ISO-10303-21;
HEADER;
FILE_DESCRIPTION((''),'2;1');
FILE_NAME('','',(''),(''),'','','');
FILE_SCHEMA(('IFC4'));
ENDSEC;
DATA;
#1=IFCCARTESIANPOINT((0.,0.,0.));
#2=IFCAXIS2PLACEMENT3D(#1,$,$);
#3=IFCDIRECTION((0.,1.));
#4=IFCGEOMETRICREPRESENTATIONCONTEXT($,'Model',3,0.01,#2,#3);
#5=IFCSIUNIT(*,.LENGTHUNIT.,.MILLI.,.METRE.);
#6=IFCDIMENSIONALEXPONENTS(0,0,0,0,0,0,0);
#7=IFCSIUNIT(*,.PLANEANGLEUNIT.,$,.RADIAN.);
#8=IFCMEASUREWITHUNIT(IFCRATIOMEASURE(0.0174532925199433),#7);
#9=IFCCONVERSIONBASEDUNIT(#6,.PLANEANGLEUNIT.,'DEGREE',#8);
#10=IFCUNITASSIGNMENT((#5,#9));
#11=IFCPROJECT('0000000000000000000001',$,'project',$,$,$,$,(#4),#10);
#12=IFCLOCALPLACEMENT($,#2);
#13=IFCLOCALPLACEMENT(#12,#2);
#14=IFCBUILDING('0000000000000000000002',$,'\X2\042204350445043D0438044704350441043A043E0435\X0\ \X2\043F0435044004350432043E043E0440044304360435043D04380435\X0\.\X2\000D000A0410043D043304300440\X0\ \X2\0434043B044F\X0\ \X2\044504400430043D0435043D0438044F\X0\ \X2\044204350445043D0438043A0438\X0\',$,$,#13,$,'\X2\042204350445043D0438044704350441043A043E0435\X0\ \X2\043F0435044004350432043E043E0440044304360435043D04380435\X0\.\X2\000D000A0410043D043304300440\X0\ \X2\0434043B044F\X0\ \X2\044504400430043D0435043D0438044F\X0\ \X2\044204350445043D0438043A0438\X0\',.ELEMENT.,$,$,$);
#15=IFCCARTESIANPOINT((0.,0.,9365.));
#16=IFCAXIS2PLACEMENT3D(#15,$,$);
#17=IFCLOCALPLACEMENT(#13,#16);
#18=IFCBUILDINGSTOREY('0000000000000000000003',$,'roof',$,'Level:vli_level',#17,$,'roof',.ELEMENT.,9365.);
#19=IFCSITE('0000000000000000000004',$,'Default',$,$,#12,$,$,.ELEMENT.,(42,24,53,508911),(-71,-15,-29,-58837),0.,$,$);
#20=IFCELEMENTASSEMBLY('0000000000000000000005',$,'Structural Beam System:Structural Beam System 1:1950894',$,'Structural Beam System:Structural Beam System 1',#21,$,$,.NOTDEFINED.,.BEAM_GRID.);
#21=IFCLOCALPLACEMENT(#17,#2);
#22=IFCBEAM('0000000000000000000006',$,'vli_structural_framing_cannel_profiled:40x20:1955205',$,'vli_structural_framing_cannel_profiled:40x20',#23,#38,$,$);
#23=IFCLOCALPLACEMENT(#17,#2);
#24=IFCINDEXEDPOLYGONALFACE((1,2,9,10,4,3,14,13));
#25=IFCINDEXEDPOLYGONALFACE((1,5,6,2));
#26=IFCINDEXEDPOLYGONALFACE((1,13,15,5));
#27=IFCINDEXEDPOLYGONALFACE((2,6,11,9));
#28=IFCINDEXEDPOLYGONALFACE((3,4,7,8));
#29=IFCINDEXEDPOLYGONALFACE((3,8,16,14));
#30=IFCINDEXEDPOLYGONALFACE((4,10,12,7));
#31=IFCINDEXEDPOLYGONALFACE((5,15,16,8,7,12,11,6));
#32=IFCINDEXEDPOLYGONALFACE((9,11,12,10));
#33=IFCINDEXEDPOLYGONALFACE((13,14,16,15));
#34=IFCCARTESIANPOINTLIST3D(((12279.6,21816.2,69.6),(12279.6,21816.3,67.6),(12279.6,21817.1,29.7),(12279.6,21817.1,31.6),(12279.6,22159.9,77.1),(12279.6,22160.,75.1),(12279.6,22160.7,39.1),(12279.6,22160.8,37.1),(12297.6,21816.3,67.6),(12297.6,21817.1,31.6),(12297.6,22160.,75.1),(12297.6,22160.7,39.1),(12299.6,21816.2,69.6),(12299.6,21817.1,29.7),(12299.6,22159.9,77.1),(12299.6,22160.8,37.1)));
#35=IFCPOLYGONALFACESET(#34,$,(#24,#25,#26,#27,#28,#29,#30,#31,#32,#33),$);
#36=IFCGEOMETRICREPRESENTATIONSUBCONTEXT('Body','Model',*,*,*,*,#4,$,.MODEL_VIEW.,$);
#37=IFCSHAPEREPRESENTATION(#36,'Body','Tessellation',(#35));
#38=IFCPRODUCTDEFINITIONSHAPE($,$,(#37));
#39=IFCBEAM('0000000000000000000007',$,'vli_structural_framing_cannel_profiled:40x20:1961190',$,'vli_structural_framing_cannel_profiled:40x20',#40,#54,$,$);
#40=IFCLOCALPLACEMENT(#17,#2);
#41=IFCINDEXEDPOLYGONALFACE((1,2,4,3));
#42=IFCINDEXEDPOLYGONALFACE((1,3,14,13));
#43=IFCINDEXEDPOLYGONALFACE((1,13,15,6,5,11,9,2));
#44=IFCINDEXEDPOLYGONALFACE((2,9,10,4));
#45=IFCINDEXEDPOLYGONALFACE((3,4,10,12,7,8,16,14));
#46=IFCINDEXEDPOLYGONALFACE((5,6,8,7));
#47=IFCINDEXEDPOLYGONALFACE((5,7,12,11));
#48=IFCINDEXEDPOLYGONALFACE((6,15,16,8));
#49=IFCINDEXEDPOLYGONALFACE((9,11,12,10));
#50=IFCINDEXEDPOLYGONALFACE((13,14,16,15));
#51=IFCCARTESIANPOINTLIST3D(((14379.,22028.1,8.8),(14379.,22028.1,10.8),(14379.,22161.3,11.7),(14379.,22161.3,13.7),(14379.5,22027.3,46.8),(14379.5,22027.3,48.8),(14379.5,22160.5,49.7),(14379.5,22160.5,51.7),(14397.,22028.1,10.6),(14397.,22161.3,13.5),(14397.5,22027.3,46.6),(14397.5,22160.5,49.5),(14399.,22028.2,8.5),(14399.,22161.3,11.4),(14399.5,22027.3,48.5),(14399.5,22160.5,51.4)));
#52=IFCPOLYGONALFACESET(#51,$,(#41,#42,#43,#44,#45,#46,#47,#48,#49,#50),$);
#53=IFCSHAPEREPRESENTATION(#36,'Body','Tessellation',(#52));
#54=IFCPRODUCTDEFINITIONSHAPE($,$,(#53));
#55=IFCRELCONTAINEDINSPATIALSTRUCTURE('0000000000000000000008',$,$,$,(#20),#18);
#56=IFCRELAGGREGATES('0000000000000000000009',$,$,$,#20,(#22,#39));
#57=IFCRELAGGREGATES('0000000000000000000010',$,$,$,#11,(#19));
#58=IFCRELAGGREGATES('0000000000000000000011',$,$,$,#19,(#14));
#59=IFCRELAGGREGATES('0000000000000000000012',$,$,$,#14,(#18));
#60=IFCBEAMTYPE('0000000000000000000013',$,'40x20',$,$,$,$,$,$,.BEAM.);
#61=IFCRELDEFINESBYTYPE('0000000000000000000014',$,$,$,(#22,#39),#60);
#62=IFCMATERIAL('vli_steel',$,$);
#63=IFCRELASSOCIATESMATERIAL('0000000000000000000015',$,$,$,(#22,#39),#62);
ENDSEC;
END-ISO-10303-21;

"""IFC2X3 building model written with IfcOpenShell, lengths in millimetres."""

from ifc_helpers import new_model, entity, si_unit, converted_unit, direction, frame, origin, place, context, subcontext, project, spatial, polyline, outline, extrude, material, type_object, element, aggregate, save


model = new_model("IFC2X3")

# Units and contexts
model_context = context("Model", 3, precision=0.01, world=origin(), true_north=direction((0.0, 1.0)))
body_context = subcontext(model_context, "Body", "Model", "MODEL_VIEW")
ifc_project = project(units=[si_unit("LENGTHUNIT", "METRE", prefix="MILLI"), converted_unit("PLANEANGLEUNIT", "DEGREE", entity("IfcRatioMeasure", 0.0174532925199433), si_unit("PLANEANGLEUNIT", "RADIAN"), dimensions=[0, 0, 0, 0, 0, 0, 0])], contexts=[model_context])

# Site, building, storey
site_placement = place(None, origin())
site = spatial("IfcSite", under=ifc_project, at=site_placement, Name="Default", CompositionType="ELEMENT", RefLatitude=(42, 24, 53, 508911), RefLongitude=(-71, -15, -29, -58837), RefElevation=0.0)
building_placement = place(site_placement, origin())
building = spatial("IfcBuilding", under=site, at=building_placement, Name="Техническое перевооружение.\r\nАнгар для хранения техники", LongName="Техническое перевооружение.\r\nАнгар для хранения техники", CompositionType="ELEMENT")
storey_placement = place(building_placement, frame((0.0, 0.0, 9365.0)))
storey = spatial("IfcBuildingStorey", under=building, at=storey_placement, Name="roof", ObjectType="Level:vli_level", LongName="roof", CompositionType="ELEMENT", Elevation=9365.0)

# Element assembly, beam
ifc_material = material(Name="vli_steel")
beam_type = type_object("IfcBeamType", Name="40x20", PredefinedType="BEAM")
assembly_1_placement = place(storey_placement, origin())
assembly_1 = element("IfcElementAssembly", 1, at=assembly_1_placement, inside=storey, Name="Structural Beam System:Structural Beam System 1:1950894", ObjectType="Structural Beam System:Structural Beam System 1", AssemblyPlace="NOTDEFINED", PredefinedType="BEAM_GRID")
beam_1_placement = place(assembly_1_placement, frame((12299.0, 22161.4, 77.2), z_axis=(0.0, -0.021793, 0.999763), x_axis=(0.0, -0.999763, -0.021793)))
beam_1 = element("IfcBeam", 2, at=beam_1_placement, type_object=beam_type, material=ifc_material, Name="vli_structural_framing_cannel_profiled:40x20:1955205", ObjectType="vli_structural_framing_cannel_profiled:40x20", context=body_context, shape_type="SweptSolid", body=[
    extrude(outline(polyline([(-20.0, -9.5), (-18.0, -9.5), (-18.0, 8.5), (18.0, 8.5), (18.0, -9.5), (20.0, -9.5), (20.0, 10.5), (-20.0, 10.5), (-20.0, -9.5)])), frame((1.5, -9.9, -20.0), z_axis=(1.0, 0.0, 0.0), x_axis=(0.0, 0.0, -1.0)), (0.0, 0.0, 1.0), 343.8),
])

# Beam
beam_2_placement = place(assembly_1_placement, frame((14398.9, 22161.9, 51.5), z_axis=(0.0, -0.021793, 0.999763), x_axis=(0.0, -0.999763, -0.021793)))
beam_2 = element("IfcBeam", 3, at=beam_2_placement, type_object=beam_type, material=ifc_material, Name="vli_structural_framing_cannel_profiled:40x20:1961190", ObjectType="vli_structural_framing_cannel_profiled:40x20", context=body_context, shape_type="SweptSolid", body=[
    extrude(outline(polyline([(-10.5, -20.0), (9.5, -20.0), (9.5, -18.0), (-8.5, -18.0), (-8.5, 18.0), (9.5, 18.0), (9.5, 20.0), (-10.5, 20.0), (-10.5, -20.0)])), frame((1.5, -10.1, -19.9), z_axis=(1.0, 0.0, 0.0), x_axis=(0.0, -0.999925, 0.012237)), (0.0, 0.0, 1.0), 133.2),
])
aggregate(assembly_1, [beam_1, beam_2])

save(model, "model.ifc")
